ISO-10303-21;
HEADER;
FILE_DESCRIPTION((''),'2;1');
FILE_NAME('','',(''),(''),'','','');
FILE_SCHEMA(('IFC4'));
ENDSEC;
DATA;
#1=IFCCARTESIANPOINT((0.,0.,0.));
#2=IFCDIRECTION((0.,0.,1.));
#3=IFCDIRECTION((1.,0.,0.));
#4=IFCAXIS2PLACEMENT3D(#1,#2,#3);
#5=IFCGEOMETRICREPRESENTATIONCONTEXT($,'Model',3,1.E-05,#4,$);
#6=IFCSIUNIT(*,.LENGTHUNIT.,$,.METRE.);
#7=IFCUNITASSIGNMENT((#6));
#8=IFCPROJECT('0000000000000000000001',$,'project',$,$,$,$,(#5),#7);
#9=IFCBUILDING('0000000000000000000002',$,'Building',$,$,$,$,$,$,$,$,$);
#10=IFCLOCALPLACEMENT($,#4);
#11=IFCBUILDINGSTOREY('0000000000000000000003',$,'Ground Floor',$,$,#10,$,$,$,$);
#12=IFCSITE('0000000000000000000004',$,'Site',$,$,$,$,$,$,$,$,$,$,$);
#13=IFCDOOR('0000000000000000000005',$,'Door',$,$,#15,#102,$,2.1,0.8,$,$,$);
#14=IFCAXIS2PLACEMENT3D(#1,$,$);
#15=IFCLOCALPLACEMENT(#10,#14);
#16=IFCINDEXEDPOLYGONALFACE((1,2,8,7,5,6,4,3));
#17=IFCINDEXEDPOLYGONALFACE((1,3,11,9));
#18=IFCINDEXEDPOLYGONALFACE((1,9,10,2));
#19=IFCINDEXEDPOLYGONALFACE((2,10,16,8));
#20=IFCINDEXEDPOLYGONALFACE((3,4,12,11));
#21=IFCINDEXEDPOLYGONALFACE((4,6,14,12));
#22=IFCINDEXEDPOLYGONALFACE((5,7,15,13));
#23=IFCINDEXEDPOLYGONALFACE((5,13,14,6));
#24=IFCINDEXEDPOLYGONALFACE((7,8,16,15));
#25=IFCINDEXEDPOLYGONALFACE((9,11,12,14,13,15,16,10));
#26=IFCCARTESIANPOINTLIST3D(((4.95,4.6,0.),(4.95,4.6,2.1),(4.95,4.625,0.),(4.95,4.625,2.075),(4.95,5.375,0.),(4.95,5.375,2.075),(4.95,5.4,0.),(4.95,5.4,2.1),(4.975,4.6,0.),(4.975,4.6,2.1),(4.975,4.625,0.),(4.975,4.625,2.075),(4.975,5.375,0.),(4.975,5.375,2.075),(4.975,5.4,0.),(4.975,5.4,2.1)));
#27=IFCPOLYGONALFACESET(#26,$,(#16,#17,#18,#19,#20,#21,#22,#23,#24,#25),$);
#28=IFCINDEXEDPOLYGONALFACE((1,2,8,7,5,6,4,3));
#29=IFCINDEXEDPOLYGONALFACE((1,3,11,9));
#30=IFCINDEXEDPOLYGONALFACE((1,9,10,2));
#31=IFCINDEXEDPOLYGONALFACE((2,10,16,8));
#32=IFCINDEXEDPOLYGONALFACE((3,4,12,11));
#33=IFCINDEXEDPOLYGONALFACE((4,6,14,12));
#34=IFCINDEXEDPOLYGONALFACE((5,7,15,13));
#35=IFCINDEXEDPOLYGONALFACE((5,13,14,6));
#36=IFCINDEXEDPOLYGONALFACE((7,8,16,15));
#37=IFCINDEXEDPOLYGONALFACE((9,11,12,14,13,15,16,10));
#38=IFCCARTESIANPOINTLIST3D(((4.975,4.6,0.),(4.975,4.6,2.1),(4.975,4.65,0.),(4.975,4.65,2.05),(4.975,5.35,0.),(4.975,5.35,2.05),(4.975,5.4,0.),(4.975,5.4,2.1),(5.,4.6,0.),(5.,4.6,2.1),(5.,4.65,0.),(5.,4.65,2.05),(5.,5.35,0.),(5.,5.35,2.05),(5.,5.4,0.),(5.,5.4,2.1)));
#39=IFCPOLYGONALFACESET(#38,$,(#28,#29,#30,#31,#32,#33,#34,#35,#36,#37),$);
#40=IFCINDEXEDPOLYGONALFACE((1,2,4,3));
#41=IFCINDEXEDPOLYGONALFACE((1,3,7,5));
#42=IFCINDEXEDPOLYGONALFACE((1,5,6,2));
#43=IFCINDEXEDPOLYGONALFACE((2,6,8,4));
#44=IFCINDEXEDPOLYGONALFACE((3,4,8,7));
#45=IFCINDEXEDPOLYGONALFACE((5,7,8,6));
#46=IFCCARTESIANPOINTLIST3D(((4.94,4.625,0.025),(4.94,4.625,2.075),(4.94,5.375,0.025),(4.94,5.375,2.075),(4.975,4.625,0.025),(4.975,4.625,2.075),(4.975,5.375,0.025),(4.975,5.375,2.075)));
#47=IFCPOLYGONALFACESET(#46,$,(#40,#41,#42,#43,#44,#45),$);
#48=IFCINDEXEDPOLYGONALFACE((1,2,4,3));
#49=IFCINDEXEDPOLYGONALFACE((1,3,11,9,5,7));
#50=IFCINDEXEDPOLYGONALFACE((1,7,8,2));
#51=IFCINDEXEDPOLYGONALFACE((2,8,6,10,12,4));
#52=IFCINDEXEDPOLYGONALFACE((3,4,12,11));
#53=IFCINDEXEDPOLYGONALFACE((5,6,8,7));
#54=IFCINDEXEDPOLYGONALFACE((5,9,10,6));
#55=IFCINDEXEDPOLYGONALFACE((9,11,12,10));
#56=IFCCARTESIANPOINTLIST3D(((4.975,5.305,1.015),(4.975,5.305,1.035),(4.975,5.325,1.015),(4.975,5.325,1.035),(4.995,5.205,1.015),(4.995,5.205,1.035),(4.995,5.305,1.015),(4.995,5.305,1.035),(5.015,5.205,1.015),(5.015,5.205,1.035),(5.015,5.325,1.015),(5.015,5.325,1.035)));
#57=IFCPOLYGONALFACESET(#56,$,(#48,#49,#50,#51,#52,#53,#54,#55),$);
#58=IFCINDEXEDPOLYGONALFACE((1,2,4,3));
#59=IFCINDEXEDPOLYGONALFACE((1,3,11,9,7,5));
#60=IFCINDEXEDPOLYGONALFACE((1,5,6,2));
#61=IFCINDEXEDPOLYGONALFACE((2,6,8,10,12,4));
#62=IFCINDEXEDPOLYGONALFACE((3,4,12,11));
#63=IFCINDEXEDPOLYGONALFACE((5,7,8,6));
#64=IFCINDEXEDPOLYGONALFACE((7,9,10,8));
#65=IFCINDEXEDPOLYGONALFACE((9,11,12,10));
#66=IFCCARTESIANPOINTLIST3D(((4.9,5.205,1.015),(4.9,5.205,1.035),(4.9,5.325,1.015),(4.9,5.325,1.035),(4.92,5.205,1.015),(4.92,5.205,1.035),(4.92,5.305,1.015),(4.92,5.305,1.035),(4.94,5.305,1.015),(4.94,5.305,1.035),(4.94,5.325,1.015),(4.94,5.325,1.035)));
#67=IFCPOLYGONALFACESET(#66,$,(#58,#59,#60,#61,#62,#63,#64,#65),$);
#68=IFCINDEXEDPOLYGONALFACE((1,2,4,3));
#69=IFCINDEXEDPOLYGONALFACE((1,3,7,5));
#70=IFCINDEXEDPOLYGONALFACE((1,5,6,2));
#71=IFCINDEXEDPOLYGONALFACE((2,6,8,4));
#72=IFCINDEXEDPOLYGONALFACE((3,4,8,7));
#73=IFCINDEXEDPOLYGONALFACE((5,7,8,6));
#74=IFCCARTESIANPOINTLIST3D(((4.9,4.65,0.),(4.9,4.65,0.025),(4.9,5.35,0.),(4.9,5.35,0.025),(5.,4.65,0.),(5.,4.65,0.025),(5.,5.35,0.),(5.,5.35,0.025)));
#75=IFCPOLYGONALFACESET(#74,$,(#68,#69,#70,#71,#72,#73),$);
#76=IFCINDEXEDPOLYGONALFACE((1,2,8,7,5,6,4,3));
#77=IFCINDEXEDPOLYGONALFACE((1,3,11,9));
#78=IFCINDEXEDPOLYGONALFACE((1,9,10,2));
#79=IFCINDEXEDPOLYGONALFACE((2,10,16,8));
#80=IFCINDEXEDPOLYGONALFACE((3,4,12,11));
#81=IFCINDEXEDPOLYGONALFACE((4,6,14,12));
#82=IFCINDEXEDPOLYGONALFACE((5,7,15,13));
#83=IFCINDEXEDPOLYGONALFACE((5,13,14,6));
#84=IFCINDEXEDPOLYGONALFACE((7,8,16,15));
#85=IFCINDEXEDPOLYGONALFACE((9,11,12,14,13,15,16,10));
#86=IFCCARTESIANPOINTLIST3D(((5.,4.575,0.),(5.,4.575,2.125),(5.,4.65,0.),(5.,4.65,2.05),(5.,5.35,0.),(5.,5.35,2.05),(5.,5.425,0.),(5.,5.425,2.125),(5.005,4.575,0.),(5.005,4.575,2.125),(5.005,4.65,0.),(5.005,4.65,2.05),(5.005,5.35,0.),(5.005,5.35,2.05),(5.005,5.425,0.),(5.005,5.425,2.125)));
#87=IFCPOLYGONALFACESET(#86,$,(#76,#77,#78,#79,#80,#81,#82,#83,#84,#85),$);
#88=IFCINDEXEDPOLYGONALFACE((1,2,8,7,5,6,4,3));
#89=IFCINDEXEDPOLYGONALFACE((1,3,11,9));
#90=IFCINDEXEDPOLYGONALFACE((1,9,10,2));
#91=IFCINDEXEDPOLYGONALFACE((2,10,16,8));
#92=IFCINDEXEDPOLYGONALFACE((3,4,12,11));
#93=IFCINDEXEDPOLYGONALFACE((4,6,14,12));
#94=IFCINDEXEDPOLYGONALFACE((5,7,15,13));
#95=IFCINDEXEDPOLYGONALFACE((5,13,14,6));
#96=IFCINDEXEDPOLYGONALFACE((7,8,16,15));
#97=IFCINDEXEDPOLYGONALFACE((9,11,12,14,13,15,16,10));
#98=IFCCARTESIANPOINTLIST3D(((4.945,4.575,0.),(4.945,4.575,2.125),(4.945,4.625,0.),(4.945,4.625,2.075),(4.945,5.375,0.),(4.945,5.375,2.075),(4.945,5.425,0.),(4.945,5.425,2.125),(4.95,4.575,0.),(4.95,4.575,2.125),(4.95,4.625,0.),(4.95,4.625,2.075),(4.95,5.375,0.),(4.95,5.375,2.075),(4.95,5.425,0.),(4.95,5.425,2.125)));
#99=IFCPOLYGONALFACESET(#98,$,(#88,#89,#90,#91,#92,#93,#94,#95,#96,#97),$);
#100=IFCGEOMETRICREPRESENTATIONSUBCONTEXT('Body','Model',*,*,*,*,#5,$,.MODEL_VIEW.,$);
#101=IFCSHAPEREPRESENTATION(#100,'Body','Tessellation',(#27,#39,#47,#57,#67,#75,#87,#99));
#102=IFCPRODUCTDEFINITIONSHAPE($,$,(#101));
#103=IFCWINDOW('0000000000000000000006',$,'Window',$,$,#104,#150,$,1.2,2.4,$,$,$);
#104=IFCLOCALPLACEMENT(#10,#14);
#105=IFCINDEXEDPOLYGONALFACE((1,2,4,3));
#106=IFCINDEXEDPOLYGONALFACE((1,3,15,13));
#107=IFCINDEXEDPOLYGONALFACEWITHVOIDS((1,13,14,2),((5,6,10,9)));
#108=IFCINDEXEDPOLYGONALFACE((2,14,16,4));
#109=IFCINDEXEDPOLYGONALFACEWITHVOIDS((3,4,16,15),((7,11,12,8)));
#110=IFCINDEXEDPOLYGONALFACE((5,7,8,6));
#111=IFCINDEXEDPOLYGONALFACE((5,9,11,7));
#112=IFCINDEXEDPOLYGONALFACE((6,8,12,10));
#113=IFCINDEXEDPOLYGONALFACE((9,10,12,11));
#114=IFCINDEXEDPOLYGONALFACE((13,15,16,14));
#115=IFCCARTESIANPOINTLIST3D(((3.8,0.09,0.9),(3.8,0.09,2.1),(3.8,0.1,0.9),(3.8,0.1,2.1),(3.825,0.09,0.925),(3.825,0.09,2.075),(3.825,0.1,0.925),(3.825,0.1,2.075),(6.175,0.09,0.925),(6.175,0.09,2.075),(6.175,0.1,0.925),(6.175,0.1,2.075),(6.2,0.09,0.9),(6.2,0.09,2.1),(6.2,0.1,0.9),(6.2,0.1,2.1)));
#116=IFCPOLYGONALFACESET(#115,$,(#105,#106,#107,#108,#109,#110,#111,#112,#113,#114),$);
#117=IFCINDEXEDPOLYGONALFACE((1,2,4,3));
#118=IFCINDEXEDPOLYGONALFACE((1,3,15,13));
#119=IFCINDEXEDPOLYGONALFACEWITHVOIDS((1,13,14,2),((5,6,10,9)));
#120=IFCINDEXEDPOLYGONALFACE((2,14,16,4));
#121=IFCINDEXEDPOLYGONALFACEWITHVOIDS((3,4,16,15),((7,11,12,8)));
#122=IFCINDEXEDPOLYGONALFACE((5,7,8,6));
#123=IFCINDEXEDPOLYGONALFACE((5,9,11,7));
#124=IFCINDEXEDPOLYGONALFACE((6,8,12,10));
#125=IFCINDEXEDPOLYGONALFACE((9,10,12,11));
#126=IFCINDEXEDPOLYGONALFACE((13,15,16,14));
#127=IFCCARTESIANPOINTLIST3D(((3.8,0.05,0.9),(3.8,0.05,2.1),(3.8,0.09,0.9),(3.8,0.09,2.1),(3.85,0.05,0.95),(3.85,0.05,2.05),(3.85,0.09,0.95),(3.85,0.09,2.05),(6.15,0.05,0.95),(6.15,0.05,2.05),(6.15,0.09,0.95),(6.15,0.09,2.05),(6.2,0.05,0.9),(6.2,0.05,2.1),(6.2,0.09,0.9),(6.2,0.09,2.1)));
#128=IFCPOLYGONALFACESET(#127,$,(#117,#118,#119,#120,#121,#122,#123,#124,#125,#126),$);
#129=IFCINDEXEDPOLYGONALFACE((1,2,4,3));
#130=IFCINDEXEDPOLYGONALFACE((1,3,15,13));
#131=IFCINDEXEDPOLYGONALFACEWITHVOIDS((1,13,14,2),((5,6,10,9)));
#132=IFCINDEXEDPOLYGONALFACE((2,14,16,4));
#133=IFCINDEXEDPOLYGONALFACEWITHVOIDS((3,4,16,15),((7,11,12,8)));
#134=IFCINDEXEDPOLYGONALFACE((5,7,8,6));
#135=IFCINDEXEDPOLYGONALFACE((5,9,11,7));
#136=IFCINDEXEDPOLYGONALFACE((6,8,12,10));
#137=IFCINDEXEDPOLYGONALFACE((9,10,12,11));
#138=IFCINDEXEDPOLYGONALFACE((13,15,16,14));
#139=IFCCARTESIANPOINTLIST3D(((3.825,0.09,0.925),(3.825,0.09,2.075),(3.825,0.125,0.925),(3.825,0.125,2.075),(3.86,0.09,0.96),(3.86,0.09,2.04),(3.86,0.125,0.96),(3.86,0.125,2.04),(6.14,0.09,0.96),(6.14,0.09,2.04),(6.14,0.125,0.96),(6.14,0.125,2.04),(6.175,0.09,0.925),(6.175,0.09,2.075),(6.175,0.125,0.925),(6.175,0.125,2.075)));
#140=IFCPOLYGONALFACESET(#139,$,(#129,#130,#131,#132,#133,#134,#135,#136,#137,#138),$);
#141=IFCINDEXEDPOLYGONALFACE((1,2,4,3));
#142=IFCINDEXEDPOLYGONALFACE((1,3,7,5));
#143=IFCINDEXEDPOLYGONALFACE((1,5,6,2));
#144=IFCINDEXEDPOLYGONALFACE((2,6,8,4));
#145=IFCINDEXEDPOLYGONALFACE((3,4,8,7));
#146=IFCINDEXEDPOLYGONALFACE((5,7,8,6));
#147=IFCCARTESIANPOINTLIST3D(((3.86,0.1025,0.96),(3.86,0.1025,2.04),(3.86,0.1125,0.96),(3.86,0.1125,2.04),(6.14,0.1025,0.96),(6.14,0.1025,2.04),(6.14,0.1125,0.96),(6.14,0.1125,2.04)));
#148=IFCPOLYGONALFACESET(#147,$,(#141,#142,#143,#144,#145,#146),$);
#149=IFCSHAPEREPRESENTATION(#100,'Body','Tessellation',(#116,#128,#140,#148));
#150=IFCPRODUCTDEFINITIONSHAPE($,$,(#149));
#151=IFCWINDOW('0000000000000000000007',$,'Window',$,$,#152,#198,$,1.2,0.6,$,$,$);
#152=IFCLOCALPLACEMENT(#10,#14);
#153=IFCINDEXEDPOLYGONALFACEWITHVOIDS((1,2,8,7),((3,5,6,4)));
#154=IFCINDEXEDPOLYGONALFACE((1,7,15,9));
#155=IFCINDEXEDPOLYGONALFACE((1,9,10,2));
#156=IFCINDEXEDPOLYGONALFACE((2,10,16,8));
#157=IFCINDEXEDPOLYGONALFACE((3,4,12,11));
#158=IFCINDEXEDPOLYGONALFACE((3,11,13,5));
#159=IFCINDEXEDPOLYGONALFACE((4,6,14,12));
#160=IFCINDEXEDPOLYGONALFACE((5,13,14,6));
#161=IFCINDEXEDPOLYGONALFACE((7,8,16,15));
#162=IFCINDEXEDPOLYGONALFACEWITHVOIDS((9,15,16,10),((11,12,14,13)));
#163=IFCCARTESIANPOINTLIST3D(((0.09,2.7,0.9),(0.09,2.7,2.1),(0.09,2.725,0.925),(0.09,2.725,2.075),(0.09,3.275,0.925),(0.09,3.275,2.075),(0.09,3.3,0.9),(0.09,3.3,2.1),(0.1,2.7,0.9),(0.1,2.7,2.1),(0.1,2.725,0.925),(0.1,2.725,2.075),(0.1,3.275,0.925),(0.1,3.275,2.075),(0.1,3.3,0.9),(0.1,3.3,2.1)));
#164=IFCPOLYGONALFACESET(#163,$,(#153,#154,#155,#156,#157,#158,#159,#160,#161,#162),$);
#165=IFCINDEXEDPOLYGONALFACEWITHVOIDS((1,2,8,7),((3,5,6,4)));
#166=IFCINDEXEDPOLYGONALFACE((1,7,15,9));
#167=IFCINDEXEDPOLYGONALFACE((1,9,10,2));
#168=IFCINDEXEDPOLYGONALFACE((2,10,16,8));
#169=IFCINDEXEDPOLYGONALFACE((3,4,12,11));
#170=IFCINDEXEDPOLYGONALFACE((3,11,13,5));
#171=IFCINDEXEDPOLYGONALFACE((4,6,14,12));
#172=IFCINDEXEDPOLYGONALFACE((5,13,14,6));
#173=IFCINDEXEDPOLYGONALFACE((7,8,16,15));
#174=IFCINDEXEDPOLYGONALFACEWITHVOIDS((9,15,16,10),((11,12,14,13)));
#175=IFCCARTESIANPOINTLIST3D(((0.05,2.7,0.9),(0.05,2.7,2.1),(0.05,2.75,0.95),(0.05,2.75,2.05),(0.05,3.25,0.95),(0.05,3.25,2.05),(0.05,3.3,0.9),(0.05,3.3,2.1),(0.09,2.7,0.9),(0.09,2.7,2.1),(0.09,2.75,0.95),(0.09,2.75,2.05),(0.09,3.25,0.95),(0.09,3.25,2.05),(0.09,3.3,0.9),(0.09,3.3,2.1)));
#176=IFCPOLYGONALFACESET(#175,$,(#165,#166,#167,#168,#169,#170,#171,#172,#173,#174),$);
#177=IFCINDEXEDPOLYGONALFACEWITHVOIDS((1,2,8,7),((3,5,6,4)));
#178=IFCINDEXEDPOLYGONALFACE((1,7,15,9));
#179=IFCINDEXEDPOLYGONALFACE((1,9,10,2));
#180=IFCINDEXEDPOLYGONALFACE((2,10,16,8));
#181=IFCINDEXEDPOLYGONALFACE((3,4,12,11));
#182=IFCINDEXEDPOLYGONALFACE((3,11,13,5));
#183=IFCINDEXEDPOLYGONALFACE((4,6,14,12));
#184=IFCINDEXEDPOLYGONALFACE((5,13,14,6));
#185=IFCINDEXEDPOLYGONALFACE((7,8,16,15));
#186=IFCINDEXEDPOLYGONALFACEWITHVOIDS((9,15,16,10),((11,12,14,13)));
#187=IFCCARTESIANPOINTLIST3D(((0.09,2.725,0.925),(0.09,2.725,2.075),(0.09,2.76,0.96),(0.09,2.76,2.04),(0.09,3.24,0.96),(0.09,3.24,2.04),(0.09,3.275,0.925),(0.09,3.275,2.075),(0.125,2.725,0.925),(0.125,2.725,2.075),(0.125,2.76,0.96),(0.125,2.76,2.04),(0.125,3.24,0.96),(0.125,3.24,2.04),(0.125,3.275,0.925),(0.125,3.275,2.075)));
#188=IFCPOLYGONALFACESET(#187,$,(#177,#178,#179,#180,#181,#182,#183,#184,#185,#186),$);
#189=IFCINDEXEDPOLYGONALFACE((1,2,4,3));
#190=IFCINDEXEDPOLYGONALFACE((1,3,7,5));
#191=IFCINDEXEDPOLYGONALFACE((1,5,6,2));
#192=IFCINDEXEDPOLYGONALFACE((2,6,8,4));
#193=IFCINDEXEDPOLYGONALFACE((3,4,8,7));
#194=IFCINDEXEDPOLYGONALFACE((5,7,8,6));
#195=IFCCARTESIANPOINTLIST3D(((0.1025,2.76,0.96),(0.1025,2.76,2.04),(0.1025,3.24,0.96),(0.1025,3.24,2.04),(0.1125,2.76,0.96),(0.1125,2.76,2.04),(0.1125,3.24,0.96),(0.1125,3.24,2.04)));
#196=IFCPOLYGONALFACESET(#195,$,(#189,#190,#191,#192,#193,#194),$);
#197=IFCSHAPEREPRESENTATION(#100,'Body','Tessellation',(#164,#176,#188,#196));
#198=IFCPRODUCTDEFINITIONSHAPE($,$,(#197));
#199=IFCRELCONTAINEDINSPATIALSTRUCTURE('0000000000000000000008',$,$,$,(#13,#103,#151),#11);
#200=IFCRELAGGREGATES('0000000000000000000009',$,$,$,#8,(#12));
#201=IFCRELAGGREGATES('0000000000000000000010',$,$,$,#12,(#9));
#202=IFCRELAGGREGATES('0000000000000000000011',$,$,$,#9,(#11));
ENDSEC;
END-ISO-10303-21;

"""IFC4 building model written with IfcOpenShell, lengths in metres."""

from ifc_helpers import new_model, si_unit, frame, origin_with_axes, place, context, subcontext, project, spatial, line, indexed_curve, outline, extrude, element, save


model = new_model("IFC4")

# Units and contexts
model_context = context("Model", 3, precision=1e-05, world=origin_with_axes())
body_context = subcontext(model_context, "Body", "Model", "MODEL_VIEW")
ifc_project = project(units=[si_unit("LENGTHUNIT", "METRE")], contexts=[model_context])

# Site, building, storey
site = spatial("IfcSite", under=ifc_project, Name="Site")
building = spatial("IfcBuilding", under=site, Name="Building")
storey_placement = place(None, origin_with_axes())
storey = spatial("IfcBuildingStorey", under=building, at=storey_placement, Name="Ground Floor")

# Door
door_1_placement = place(storey_placement, frame((5.0, 4.6, 0.0), z_axis=(0.0, 0.0, 1.0), x_axis=(0.0, 1.0, 0.0)))
element("IfcDoor", 1, at=door_1_placement, inside=storey, Name="Door", OverallHeight=2.1, OverallWidth=0.8, context=body_context, shape_type="SweptSolid", body=[
    extrude(outline(indexed_curve([(0.0, 0.0), (0.0, 2.1), (0.8, 2.1), (0.8, 0.0), (0.775, 0.0), (0.775, 2.075), (0.025, 2.075), (0.025, 0.0)], segments=[line(1, 2, 3, 4, 5, 6, 7, 8, 1)])), frame((0.0, 0.025, 0.0), z_axis=(0.0, -1.0, 0.0), x_axis=(1.0, 0.0, 0.0)), (0.0, 0.0, -1.0), 0.025),
    extrude(outline(indexed_curve([(0.0, 0.0), (0.0, 2.1), (0.8, 2.1), (0.8, 0.0), (0.75, 0.0), (0.75, 2.05), (0.05, 2.05), (0.05, 0.0)], segments=[line(1, 2, 3, 4, 5, 6, 7, 8, 1)])), frame((0.0, 0.0, 0.0), z_axis=(0.0, -1.0, 0.0), x_axis=(1.0, 0.0, 0.0)), (0.0, 0.0, -1.0), 0.025),
    extrude(outline(indexed_curve([(0.0, 0.0), (0.75, 0.0), (0.75, 0.035), (0.0, 0.035)], segments=[line(1, 2, 3, 4, 1)])), frame((0.025, 0.025, 0.025), z_axis=(0.0, 0.0, 1.0), x_axis=(1.0, 0.0, 0.0)), (0.0, 0.0, 1.0), 2.05),
    extrude(outline(indexed_curve([(0.0, 0.0), (0.0, -0.04), (-0.12, -0.04), (-0.12, -0.02), (-0.02, -0.02), (-0.02, 0.0)], segments=[line(1, 2, 3, 4, 5, 6, 1)])), frame((0.725, 0.025, 1.015), z_axis=(0.0, 0.0, 1.0), x_axis=(1.0, 0.0, 0.0)), (0.0, 0.0, 1.0), 0.02),
    extrude(outline(indexed_curve([(0.0, 0.0), (0.0, 0.04), (-0.12, 0.04), (-0.12, 0.02), (-0.02, 0.02), (-0.02, 0.0)], segments=[line(1, 2, 3, 4, 5, 6, 1)])), frame((0.725, 0.06, 1.015), z_axis=(0.0, 0.0, 1.0), x_axis=(1.0, 0.0, 0.0)), (0.0, 0.0, 1.0), 0.02),
    extrude(outline(indexed_curve([(0.0, 0.0), (0.7, 0.0), (0.7, 0.1), (0.0, 0.1)], segments=[line(1, 2, 3, 4, 1)])), frame((0.05, 0.0, 0.0), z_axis=(0.0, 0.0, 1.0), x_axis=(1.0, 0.0, 0.0)), (0.0, 0.0, 1.0), 0.025),
    extrude(outline(indexed_curve([(0.0, 0.0), (0.0, 2.125), (0.85, 2.125), (0.85, 0.0), (0.775, 0.0), (0.775, 2.05), (0.075, 2.05), (0.075, 0.0)], segments=[line(1, 2, 3, 4, 5, 6, 7, 8, 1)])), frame((-0.025, -0.005, 0.0), z_axis=(0.0, -1.0, 0.0), x_axis=(1.0, 0.0, 0.0)), (0.0, 0.0, -1.0), 0.005),
    extrude(outline(indexed_curve([(0.0, 0.0), (0.0, 2.125), (0.85, 2.125), (0.85, 0.0), (0.8, 0.0), (0.8, 2.075), (0.05, 2.075), (0.05, 0.0)], segments=[line(1, 2, 3, 4, 5, 6, 7, 8, 1)])), frame((-0.025, 0.05, 0.0), z_axis=(0.0, -1.0, 0.0), x_axis=(1.0, 0.0, 0.0)), (0.0, 0.0, -1.0), 0.005),
])

# Windows
window_1_placement = place(storey_placement, frame((3.8, 0.0, 0.9), z_axis=(0.0, 0.0, 1.0), x_axis=(1.0, 0.0, 0.0)))
element("IfcWindow", 2, at=window_1_placement, inside=storey, Name="Window", OverallHeight=1.2, OverallWidth=2.4, context=body_context, shape_type="SweptSolid", body=[
    extrude(outline(indexed_curve([(0.0, 0.0), (2.4, 0.0), (2.4, 1.2), (0.0, 1.2)], segments=[line(1, 2, 3, 4, 1)]), holes=[indexed_curve([(0.025, 0.025), (2.375, 0.025), (2.375, 1.175), (0.025, 1.175)], segments=[line(1, 2, 3, 4, 1)])]), frame((0.0, 0.09, 0.0), z_axis=(0.0, -1.0, 0.0), x_axis=(1.0, 0.0, 0.0)), (0.0, 0.0, -1.0), 0.01),
    extrude(outline(indexed_curve([(0.0, 0.0), (2.4, 0.0), (2.4, 1.2), (0.0, 1.2)], segments=[line(1, 2, 3, 4, 1)]), holes=[indexed_curve([(0.05, 0.05), (2.35, 0.05), (2.35, 1.15), (0.05, 1.15)], segments=[line(1, 2, 3, 4, 1)])]), frame((0.0, 0.05, 0.0), z_axis=(0.0, -1.0, 0.0), x_axis=(1.0, 0.0, 0.0)), (0.0, 0.0, -1.0), 0.04),
    extrude(outline(indexed_curve([(0.0, 0.0), (2.35, 0.0), (2.35, 1.15), (0.0, 1.15)], segments=[line(1, 2, 3, 4, 1)]), holes=[indexed_curve([(0.035, 0.035), (2.315, 0.035), (2.315, 1.115), (0.035, 1.115)], segments=[line(1, 2, 3, 4, 1)])]), frame((0.025, 0.09, 0.025), z_axis=(0.0, -1.0, 0.0), x_axis=(1.0, 0.0, 0.0)), (0.0, 0.0, -1.0), 0.035),
    extrude(outline(indexed_curve([(0.035, 0.035), (2.315, 0.035), (2.315, 1.115), (0.035, 1.115)], segments=[line(1, 2, 3, 4, 1)])), frame((0.025, 0.1025, 0.025), z_axis=(0.0, -1.0, 0.0), x_axis=(1.0, 0.0, 0.0)), (0.0, 0.0, -1.0), 0.01),
])
window_2_placement = place(storey_placement, frame((0.0, 3.3, 0.9), z_axis=(0.0, 0.0, 1.0), x_axis=(0.0, -1.0, 0.0)))
element("IfcWindow", 3, at=window_2_placement, inside=storey, Name="Window", OverallHeight=1.2, OverallWidth=0.6, context=body_context, shape_type="SweptSolid", body=[
    extrude(outline(indexed_curve([(0.0, 0.0), (0.6, 0.0), (0.6, 1.2), (0.0, 1.2)], segments=[line(1, 2, 3, 4, 1)]), holes=[indexed_curve([(0.025, 0.025), (0.575, 0.025), (0.575, 1.175), (0.025, 1.175)], segments=[line(1, 2, 3, 4, 1)])]), frame((0.0, 0.09, 0.0), z_axis=(0.0, -1.0, 0.0), x_axis=(1.0, 0.0, 0.0)), (0.0, 0.0, -1.0), 0.01),
    extrude(outline(indexed_curve([(0.0, 0.0), (0.6, 0.0), (0.6, 1.2), (0.0, 1.2)], segments=[line(1, 2, 3, 4, 1)]), holes=[indexed_curve([(0.05, 0.05), (0.55, 0.05), (0.55, 1.15), (0.05, 1.15)], segments=[line(1, 2, 3, 4, 1)])]), frame((0.0, 0.05, 0.0), z_axis=(0.0, -1.0, 0.0), x_axis=(1.0, 0.0, 0.0)), (0.0, 0.0, -1.0), 0.04),
    extrude(outline(indexed_curve([(0.0, 0.0), (0.55, 0.0), (0.55, 1.15), (0.0, 1.15)], segments=[line(1, 2, 3, 4, 1)]), holes=[indexed_curve([(0.035, 0.035), (0.515, 0.035), (0.515, 1.115), (0.035, 1.115)], segments=[line(1, 2, 3, 4, 1)])]), frame((0.025, 0.09, 0.025), z_axis=(0.0, -1.0, 0.0), x_axis=(1.0, 0.0, 0.0)), (0.0, 0.0, -1.0), 0.035),
    extrude(outline(indexed_curve([(0.035, 0.035), (0.515, 0.035), (0.515, 1.115), (0.035, 1.115)], segments=[line(1, 2, 3, 4, 1)])), frame((0.025, 0.1025, 0.025), z_axis=(0.0, -1.0, 0.0), x_axis=(1.0, 0.0, 0.0)), (0.0, 0.0, -1.0), 0.01),
])

save(model, "model.ifc")
